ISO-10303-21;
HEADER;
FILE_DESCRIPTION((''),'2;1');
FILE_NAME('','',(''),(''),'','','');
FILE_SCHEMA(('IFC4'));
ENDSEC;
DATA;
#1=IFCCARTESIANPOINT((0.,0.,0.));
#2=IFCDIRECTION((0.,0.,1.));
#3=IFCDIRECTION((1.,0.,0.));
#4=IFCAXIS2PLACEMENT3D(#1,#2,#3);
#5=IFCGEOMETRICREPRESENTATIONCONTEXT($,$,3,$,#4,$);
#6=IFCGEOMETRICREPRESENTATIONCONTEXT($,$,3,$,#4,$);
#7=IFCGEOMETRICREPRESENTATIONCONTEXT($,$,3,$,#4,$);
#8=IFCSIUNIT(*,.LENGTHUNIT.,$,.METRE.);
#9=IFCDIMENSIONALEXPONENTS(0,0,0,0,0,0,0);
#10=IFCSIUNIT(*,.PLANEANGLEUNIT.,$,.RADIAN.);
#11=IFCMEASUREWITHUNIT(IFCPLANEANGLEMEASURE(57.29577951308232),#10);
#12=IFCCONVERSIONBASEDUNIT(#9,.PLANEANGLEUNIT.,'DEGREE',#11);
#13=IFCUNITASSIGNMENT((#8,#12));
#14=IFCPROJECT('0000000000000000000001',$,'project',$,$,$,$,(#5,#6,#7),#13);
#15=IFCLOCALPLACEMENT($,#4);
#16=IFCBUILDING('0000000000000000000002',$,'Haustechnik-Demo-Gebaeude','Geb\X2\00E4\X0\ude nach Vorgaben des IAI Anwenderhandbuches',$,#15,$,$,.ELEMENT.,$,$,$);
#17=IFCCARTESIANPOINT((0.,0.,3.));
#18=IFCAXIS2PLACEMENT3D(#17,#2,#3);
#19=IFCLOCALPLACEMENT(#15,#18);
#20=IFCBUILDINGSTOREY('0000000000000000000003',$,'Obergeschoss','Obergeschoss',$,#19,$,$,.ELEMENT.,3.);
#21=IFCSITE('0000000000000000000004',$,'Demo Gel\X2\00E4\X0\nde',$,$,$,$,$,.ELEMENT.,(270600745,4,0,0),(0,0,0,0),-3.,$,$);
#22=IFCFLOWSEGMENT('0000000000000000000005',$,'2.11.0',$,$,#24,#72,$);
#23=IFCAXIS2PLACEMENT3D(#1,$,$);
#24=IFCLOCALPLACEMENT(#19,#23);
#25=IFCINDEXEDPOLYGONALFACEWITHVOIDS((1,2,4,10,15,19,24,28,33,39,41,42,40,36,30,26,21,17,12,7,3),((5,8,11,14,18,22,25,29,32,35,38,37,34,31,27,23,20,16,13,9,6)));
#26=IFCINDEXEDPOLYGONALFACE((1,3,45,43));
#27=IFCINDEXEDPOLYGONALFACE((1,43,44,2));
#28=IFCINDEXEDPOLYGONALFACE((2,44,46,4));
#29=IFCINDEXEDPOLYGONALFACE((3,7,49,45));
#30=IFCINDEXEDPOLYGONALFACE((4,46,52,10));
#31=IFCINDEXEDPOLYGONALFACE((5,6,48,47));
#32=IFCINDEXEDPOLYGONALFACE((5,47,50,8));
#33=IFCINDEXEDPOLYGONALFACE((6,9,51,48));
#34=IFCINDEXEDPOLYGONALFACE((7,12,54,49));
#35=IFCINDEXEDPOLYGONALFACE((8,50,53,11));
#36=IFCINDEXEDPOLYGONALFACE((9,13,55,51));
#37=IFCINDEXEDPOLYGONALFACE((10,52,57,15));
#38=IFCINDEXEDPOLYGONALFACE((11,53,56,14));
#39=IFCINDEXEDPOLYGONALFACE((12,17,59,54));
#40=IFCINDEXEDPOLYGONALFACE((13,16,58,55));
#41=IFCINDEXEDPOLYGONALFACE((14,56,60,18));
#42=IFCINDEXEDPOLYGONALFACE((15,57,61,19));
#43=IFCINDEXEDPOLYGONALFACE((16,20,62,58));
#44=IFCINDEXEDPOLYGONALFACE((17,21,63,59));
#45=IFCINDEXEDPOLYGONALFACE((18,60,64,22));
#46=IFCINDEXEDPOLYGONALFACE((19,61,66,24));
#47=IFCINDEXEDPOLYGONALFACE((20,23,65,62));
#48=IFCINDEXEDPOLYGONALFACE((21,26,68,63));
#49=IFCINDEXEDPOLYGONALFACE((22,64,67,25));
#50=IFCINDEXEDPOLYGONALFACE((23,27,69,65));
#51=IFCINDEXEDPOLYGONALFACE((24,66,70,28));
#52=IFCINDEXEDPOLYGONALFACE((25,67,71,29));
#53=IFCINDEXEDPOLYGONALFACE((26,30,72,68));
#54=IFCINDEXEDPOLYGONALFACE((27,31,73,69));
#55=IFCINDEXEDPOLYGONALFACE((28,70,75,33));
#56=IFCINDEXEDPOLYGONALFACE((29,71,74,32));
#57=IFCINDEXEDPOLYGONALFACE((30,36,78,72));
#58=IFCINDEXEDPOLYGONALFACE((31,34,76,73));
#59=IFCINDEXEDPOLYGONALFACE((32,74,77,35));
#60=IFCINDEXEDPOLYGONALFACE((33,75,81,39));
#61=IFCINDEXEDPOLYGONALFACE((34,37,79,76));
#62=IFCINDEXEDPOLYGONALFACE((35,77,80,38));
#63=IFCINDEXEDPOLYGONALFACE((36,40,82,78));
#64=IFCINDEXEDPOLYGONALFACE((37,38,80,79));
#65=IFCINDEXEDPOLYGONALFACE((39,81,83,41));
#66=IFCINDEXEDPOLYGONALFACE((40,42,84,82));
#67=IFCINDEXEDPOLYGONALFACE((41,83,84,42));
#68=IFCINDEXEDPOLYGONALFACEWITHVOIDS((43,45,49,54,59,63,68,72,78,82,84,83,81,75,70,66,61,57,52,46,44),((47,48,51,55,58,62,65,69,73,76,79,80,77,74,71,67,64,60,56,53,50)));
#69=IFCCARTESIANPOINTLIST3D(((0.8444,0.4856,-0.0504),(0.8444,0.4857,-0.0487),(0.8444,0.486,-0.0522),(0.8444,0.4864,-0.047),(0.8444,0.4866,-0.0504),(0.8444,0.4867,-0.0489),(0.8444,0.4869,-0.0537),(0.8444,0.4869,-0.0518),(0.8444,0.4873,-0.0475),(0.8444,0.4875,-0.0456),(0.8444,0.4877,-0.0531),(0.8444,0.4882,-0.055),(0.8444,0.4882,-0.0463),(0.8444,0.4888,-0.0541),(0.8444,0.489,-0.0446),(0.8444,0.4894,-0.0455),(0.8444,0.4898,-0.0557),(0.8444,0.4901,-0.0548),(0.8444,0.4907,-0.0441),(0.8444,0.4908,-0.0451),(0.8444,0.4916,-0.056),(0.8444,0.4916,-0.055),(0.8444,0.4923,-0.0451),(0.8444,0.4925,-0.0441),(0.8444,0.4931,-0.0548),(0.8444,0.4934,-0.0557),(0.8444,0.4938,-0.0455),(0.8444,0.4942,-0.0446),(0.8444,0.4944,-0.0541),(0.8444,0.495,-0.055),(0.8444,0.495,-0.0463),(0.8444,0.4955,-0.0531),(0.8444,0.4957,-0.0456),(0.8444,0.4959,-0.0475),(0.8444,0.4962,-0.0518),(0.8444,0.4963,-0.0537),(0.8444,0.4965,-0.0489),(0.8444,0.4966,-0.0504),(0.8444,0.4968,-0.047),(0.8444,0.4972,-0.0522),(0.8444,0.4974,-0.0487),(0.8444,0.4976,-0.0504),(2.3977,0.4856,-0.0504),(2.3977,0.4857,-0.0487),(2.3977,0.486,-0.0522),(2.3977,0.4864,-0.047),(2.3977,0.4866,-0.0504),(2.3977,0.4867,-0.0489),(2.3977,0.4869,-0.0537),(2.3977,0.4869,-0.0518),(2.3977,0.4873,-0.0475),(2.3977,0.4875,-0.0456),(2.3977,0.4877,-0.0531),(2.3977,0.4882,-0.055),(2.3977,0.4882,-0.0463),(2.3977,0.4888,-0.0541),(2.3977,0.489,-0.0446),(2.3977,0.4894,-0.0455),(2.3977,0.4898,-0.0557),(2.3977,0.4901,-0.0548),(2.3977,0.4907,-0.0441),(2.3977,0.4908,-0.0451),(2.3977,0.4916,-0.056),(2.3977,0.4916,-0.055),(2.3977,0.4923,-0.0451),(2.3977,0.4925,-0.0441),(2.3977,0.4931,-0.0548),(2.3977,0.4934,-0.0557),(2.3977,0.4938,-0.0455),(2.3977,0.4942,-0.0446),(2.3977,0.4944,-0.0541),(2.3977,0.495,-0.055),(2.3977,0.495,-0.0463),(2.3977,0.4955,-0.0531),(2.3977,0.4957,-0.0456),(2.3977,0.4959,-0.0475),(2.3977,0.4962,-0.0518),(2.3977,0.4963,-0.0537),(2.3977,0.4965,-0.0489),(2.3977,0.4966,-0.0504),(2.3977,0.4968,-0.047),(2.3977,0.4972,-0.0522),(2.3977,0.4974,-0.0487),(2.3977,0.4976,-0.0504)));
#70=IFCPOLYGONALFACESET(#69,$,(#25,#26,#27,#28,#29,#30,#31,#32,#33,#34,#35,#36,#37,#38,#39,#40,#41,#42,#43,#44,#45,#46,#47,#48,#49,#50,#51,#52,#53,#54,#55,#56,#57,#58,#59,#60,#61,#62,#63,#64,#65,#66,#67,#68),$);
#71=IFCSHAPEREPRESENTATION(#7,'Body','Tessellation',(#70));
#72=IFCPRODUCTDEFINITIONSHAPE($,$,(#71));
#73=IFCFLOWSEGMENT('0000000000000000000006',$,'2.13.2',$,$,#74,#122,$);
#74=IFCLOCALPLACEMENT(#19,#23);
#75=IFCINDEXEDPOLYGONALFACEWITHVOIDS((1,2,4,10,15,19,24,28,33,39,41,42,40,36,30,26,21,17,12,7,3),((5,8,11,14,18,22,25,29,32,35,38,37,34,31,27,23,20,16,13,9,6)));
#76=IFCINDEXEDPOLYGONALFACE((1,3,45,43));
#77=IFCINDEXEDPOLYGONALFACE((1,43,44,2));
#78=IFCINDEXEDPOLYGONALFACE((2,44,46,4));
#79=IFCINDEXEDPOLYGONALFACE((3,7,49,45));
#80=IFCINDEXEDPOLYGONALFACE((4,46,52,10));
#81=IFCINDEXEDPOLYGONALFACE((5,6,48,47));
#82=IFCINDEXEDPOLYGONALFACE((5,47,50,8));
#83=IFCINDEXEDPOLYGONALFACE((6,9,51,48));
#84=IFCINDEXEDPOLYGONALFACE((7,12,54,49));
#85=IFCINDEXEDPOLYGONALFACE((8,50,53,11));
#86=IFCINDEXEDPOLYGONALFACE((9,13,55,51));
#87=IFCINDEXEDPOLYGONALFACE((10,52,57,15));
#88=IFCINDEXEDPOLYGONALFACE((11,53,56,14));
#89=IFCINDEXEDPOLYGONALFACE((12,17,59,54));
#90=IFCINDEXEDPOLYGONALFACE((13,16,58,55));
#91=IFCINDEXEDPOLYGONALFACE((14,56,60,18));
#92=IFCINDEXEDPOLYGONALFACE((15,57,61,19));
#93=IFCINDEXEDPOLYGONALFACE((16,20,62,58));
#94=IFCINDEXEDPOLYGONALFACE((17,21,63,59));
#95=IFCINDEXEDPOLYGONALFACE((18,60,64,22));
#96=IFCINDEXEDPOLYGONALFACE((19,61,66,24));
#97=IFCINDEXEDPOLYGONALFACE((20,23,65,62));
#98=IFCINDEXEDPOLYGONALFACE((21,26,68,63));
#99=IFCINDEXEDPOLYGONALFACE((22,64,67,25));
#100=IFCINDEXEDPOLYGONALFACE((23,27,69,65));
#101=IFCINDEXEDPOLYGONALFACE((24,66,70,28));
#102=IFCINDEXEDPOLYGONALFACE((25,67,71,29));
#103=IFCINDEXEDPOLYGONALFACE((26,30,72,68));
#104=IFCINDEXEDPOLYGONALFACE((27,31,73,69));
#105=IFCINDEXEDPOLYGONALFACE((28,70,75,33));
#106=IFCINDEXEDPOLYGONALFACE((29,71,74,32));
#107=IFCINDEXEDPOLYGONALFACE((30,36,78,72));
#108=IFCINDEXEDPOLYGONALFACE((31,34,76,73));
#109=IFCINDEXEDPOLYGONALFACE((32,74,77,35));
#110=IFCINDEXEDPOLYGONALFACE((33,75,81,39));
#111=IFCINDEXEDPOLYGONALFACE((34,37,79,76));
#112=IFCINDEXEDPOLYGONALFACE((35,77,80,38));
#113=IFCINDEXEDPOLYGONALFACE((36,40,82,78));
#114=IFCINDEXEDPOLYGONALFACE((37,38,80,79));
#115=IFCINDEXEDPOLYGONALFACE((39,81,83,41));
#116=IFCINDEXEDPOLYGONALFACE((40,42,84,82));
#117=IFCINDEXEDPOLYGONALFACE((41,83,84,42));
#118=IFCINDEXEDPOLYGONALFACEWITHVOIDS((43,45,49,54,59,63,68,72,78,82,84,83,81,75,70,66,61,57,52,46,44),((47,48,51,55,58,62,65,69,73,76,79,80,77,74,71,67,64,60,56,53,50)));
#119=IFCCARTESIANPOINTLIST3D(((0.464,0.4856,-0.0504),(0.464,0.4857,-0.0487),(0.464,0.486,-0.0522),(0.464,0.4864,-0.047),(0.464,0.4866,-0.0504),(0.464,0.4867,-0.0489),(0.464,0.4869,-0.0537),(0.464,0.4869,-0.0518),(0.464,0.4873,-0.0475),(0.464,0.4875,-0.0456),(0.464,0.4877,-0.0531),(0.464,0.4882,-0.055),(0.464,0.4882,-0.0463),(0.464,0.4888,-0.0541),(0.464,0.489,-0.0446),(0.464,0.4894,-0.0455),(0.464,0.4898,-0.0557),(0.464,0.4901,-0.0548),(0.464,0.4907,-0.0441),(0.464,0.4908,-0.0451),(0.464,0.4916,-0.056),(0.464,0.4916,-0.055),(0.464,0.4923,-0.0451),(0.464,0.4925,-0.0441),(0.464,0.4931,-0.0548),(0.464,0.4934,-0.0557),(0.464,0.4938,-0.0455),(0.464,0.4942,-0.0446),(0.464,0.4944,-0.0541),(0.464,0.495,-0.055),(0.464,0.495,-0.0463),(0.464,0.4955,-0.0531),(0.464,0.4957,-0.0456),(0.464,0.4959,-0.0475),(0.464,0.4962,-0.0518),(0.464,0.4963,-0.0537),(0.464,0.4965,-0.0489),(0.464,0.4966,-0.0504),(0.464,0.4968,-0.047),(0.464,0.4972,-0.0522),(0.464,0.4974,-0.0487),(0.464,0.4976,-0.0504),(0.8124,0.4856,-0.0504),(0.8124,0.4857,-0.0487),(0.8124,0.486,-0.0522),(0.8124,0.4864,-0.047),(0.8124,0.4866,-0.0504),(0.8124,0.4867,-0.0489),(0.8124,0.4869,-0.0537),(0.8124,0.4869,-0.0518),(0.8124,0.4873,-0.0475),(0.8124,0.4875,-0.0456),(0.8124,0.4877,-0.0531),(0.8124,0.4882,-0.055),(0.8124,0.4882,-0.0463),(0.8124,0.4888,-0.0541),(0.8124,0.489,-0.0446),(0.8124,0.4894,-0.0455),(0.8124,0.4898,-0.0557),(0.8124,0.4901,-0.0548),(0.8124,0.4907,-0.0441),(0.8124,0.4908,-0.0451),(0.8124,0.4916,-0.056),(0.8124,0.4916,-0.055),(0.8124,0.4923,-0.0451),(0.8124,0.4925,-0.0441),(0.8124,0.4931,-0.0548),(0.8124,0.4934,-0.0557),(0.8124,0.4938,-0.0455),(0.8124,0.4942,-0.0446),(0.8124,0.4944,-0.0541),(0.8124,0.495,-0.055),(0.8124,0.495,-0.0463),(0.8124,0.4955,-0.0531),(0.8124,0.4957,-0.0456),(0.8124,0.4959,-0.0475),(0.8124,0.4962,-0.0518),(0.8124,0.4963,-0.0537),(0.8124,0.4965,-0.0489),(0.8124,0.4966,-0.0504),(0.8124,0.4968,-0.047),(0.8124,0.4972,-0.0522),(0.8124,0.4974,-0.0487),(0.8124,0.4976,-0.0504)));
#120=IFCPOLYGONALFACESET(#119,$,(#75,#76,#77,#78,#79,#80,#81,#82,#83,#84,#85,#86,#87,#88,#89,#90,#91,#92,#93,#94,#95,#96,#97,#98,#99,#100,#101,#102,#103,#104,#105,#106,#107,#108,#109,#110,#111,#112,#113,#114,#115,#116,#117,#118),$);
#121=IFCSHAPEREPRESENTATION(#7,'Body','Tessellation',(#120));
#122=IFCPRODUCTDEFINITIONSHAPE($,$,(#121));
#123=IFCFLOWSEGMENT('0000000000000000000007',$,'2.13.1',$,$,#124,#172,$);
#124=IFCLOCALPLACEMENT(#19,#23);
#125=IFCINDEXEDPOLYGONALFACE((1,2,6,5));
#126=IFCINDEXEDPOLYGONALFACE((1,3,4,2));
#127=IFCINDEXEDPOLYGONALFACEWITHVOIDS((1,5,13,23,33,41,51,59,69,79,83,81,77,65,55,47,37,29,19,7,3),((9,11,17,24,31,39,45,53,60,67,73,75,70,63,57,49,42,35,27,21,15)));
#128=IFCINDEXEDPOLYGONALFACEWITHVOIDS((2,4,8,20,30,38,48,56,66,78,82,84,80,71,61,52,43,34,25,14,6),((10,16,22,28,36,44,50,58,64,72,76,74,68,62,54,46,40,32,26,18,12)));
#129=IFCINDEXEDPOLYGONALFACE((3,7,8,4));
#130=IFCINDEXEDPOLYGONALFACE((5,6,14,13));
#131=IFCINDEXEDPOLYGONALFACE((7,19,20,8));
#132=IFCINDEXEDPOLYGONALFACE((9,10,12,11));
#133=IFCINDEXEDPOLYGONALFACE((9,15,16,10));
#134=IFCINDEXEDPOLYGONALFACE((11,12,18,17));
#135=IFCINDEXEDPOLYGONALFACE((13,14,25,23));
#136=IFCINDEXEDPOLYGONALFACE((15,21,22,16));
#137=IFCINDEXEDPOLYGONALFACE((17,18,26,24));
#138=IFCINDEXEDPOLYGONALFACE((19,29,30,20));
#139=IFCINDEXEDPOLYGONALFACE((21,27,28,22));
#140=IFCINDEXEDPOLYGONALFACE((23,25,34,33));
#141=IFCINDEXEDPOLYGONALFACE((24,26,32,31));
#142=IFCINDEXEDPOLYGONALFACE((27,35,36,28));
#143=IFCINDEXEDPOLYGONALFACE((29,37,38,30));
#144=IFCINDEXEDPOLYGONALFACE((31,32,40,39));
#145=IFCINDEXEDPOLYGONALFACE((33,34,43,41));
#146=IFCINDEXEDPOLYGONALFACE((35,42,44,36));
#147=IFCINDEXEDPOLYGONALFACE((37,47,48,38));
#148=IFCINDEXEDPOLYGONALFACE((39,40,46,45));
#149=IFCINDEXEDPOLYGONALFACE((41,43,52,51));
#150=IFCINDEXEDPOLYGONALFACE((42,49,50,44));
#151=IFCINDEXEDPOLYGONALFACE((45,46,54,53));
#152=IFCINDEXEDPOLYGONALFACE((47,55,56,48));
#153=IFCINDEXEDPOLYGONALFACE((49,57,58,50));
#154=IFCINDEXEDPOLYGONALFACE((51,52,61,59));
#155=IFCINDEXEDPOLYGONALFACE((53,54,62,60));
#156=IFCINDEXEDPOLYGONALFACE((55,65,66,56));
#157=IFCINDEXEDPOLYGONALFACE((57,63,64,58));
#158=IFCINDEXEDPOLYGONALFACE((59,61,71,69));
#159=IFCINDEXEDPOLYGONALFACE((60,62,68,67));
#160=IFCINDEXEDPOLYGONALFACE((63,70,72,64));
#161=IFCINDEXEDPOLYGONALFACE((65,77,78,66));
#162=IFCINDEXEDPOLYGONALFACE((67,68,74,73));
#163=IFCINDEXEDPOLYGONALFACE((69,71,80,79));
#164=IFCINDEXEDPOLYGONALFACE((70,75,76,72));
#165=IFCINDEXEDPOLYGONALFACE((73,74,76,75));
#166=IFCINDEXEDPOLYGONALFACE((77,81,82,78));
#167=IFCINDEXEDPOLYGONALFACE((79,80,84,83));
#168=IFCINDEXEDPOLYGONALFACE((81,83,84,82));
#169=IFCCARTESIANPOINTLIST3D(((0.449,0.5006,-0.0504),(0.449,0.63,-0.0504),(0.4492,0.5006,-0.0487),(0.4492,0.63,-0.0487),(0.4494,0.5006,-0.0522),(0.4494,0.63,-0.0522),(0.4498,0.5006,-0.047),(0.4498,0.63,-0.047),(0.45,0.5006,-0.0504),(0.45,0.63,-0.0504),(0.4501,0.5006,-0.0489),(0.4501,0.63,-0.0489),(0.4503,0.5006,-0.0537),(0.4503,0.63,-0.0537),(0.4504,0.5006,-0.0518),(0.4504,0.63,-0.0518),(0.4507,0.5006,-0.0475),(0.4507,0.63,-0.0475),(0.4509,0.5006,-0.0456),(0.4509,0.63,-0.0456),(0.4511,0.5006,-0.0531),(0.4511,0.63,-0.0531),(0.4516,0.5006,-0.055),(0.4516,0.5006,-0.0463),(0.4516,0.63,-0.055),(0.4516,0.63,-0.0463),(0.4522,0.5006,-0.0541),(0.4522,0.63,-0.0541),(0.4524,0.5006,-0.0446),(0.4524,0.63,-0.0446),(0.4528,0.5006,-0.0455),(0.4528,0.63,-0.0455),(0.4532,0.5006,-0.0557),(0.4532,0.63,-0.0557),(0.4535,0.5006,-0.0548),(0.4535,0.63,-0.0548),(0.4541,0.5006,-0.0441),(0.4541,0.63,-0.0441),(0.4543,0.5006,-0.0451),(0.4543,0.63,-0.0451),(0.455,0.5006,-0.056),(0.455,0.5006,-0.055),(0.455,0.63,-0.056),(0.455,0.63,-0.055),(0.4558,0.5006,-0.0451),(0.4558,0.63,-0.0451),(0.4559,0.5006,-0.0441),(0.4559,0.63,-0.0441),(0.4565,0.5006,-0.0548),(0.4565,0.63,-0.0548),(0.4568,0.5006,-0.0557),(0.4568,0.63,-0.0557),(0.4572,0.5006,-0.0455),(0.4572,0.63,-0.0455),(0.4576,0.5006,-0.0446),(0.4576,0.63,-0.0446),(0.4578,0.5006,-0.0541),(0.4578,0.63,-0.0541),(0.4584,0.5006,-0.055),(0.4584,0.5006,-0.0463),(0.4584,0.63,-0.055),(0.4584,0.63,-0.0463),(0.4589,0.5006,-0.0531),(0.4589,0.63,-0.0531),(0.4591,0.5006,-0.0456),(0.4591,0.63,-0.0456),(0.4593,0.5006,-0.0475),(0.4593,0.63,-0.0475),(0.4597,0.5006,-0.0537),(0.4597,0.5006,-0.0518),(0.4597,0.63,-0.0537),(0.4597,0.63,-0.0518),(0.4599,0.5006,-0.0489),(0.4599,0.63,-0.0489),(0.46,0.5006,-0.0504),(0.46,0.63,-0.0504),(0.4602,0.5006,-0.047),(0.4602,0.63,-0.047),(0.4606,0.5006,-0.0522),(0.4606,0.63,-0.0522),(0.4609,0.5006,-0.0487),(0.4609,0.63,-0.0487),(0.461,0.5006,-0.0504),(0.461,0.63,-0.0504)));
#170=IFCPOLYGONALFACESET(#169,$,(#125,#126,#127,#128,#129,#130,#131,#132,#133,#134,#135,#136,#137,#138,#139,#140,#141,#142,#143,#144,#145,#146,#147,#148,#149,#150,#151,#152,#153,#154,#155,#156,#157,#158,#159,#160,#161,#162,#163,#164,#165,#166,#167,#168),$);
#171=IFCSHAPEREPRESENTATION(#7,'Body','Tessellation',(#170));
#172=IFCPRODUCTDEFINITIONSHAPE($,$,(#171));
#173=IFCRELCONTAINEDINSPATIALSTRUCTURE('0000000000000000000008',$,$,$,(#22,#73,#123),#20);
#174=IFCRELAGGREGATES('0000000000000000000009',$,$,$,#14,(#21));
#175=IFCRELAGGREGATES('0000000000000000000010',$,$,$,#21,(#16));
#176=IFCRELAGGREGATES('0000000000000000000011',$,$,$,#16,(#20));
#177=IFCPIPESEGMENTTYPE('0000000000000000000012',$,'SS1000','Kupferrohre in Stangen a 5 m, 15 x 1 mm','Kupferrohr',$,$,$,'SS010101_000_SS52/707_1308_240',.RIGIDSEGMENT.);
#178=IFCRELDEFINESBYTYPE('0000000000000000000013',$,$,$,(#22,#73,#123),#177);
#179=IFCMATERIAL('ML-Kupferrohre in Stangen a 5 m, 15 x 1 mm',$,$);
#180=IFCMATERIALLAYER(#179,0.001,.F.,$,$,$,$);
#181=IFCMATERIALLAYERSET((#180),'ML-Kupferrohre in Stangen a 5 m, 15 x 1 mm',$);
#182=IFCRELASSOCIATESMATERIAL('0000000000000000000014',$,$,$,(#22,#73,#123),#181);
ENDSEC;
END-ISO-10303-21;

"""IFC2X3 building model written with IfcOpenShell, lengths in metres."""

from ifc_helpers import new_model, entity, si_unit, converted_unit, frame, origin_with_axes, origin_2d_with_axis, place, context, project, spatial, hollow_circle, extrude, material, layer, layer_set, layer_usage, type_object, element, save


model = new_model("IFC2X3")

# Units and contexts
context_of_model_1 = context(None, 3, world=origin_with_axes())
context_of_model_2 = context(None, 3, world=origin_with_axes())
context_of_model_3 = context(None, 3, world=origin_with_axes())
ifc_project = project(units=[si_unit("LENGTHUNIT", "METRE"), converted_unit("PLANEANGLEUNIT", "DEGREE", entity("IfcPlaneAngleMeasure", 57.29577951308232), si_unit("PLANEANGLEUNIT", "RADIAN"), dimensions=[0, 0, 0, 0, 0, 0, 0])], contexts=[context_of_model_1, context_of_model_2, context_of_model_3])

# Site, building, storey
site = spatial("IfcSite", under=ifc_project, Name="Demo Gelände", CompositionType="ELEMENT", RefLatitude=(270600745, 4, 0, 0), RefLongitude=(0, 0, 0, 0), RefElevation=-3.0)
building_placement = place(None, origin_with_axes())
building = spatial("IfcBuilding", under=site, at=building_placement, Name="Haustechnik-Demo-Gebaeude", Description="Gebäude nach Vorgaben des IAI Anwenderhandbuches", CompositionType="ELEMENT")
storey_placement = place(building_placement, frame((0.0, 0.0, 3.0), z_axis=(0.0, 0.0, 1.0), x_axis=(1.0, 0.0, 0.0)))
storey = spatial("IfcBuildingStorey", under=building, at=storey_placement, Name="Obergeschoss", Description="Obergeschoss", CompositionType="ELEMENT", Elevation=3.0)

# Flow segments
ifc_material = material(Name="ML-Kupferrohre in Stangen a 5 m, 15 x 1 mm")
ifc_layer = layer(ifc_material, 0.001, ventilated=False)
ifc_layer_set = layer_set([ifc_layer], Name="ML-Kupferrohre in Stangen a 5 m, 15 x 1 mm")
ifc_layer_usage = layer_usage(ifc_layer_set, "AXIS2", "POSITIVE", 0.0)
pipe_segment_type_1 = type_object("IfcPipeSegmentType", Name="SS1000", Description="Kupferrohre in Stangen a 5 m, 15 x 1 mm", ApplicableOccurrence="Kupferrohr", ElementType="SS010101_000_SS52/707_1308_240", PredefinedType="RIGIDSEGMENT")
flow_segment_1_placement = place(storey_placement, frame((2.3977, 0.4916, -0.05), z_axis=(-1.0, 0.0, 0.0), x_axis=(0.0, 0.0, -1.0)))
element("IfcFlowSegment", 1, at=flow_segment_1_placement, inside=storey, type_object=pipe_segment_type_1, material=ifc_layer_usage, Name="2.11.0", context=context_of_model_3, shape_type="SweptSolid", body=[
    extrude(hollow_circle(Radius=0.006, WallThickness=0.001, at=origin_2d_with_axis()), origin_with_axes(), (0.0, 0.0, 1.0), 1.5533),
])
flow_segment_2_placement = place(storey_placement, frame((0.8124, 0.4916, -0.05), z_axis=(-1.0, 0.0, 0.0), x_axis=(0.0, 0.0, -1.0)))
element("IfcFlowSegment", 2, at=flow_segment_2_placement, inside=storey, type_object=pipe_segment_type_1, material=ifc_layer_usage, Name="2.13.2", context=context_of_model_3, shape_type="SweptSolid", body=[
    extrude(hollow_circle(Radius=0.006, WallThickness=0.001, at=origin_2d_with_axis()), origin_with_axes(), (0.0, 0.0, 1.0), 0.3483),
])
flow_segment_3_placement = place(storey_placement, frame((0.455, 0.5006, -0.05), z_axis=(0.0, 1.0, 0.0), x_axis=(0.0, 0.0, -1.0)))
element("IfcFlowSegment", 3, at=flow_segment_3_placement, inside=storey, type_object=pipe_segment_type_1, material=ifc_layer_usage, Name="2.13.1", context=context_of_model_3, shape_type="SweptSolid", body=[
    extrude(hollow_circle(Radius=0.006, WallThickness=0.001, at=origin_2d_with_axis()), origin_with_axes(), (0.0, 0.0, 1.0), 0.1294),
])

save(model, "model.ifc")
